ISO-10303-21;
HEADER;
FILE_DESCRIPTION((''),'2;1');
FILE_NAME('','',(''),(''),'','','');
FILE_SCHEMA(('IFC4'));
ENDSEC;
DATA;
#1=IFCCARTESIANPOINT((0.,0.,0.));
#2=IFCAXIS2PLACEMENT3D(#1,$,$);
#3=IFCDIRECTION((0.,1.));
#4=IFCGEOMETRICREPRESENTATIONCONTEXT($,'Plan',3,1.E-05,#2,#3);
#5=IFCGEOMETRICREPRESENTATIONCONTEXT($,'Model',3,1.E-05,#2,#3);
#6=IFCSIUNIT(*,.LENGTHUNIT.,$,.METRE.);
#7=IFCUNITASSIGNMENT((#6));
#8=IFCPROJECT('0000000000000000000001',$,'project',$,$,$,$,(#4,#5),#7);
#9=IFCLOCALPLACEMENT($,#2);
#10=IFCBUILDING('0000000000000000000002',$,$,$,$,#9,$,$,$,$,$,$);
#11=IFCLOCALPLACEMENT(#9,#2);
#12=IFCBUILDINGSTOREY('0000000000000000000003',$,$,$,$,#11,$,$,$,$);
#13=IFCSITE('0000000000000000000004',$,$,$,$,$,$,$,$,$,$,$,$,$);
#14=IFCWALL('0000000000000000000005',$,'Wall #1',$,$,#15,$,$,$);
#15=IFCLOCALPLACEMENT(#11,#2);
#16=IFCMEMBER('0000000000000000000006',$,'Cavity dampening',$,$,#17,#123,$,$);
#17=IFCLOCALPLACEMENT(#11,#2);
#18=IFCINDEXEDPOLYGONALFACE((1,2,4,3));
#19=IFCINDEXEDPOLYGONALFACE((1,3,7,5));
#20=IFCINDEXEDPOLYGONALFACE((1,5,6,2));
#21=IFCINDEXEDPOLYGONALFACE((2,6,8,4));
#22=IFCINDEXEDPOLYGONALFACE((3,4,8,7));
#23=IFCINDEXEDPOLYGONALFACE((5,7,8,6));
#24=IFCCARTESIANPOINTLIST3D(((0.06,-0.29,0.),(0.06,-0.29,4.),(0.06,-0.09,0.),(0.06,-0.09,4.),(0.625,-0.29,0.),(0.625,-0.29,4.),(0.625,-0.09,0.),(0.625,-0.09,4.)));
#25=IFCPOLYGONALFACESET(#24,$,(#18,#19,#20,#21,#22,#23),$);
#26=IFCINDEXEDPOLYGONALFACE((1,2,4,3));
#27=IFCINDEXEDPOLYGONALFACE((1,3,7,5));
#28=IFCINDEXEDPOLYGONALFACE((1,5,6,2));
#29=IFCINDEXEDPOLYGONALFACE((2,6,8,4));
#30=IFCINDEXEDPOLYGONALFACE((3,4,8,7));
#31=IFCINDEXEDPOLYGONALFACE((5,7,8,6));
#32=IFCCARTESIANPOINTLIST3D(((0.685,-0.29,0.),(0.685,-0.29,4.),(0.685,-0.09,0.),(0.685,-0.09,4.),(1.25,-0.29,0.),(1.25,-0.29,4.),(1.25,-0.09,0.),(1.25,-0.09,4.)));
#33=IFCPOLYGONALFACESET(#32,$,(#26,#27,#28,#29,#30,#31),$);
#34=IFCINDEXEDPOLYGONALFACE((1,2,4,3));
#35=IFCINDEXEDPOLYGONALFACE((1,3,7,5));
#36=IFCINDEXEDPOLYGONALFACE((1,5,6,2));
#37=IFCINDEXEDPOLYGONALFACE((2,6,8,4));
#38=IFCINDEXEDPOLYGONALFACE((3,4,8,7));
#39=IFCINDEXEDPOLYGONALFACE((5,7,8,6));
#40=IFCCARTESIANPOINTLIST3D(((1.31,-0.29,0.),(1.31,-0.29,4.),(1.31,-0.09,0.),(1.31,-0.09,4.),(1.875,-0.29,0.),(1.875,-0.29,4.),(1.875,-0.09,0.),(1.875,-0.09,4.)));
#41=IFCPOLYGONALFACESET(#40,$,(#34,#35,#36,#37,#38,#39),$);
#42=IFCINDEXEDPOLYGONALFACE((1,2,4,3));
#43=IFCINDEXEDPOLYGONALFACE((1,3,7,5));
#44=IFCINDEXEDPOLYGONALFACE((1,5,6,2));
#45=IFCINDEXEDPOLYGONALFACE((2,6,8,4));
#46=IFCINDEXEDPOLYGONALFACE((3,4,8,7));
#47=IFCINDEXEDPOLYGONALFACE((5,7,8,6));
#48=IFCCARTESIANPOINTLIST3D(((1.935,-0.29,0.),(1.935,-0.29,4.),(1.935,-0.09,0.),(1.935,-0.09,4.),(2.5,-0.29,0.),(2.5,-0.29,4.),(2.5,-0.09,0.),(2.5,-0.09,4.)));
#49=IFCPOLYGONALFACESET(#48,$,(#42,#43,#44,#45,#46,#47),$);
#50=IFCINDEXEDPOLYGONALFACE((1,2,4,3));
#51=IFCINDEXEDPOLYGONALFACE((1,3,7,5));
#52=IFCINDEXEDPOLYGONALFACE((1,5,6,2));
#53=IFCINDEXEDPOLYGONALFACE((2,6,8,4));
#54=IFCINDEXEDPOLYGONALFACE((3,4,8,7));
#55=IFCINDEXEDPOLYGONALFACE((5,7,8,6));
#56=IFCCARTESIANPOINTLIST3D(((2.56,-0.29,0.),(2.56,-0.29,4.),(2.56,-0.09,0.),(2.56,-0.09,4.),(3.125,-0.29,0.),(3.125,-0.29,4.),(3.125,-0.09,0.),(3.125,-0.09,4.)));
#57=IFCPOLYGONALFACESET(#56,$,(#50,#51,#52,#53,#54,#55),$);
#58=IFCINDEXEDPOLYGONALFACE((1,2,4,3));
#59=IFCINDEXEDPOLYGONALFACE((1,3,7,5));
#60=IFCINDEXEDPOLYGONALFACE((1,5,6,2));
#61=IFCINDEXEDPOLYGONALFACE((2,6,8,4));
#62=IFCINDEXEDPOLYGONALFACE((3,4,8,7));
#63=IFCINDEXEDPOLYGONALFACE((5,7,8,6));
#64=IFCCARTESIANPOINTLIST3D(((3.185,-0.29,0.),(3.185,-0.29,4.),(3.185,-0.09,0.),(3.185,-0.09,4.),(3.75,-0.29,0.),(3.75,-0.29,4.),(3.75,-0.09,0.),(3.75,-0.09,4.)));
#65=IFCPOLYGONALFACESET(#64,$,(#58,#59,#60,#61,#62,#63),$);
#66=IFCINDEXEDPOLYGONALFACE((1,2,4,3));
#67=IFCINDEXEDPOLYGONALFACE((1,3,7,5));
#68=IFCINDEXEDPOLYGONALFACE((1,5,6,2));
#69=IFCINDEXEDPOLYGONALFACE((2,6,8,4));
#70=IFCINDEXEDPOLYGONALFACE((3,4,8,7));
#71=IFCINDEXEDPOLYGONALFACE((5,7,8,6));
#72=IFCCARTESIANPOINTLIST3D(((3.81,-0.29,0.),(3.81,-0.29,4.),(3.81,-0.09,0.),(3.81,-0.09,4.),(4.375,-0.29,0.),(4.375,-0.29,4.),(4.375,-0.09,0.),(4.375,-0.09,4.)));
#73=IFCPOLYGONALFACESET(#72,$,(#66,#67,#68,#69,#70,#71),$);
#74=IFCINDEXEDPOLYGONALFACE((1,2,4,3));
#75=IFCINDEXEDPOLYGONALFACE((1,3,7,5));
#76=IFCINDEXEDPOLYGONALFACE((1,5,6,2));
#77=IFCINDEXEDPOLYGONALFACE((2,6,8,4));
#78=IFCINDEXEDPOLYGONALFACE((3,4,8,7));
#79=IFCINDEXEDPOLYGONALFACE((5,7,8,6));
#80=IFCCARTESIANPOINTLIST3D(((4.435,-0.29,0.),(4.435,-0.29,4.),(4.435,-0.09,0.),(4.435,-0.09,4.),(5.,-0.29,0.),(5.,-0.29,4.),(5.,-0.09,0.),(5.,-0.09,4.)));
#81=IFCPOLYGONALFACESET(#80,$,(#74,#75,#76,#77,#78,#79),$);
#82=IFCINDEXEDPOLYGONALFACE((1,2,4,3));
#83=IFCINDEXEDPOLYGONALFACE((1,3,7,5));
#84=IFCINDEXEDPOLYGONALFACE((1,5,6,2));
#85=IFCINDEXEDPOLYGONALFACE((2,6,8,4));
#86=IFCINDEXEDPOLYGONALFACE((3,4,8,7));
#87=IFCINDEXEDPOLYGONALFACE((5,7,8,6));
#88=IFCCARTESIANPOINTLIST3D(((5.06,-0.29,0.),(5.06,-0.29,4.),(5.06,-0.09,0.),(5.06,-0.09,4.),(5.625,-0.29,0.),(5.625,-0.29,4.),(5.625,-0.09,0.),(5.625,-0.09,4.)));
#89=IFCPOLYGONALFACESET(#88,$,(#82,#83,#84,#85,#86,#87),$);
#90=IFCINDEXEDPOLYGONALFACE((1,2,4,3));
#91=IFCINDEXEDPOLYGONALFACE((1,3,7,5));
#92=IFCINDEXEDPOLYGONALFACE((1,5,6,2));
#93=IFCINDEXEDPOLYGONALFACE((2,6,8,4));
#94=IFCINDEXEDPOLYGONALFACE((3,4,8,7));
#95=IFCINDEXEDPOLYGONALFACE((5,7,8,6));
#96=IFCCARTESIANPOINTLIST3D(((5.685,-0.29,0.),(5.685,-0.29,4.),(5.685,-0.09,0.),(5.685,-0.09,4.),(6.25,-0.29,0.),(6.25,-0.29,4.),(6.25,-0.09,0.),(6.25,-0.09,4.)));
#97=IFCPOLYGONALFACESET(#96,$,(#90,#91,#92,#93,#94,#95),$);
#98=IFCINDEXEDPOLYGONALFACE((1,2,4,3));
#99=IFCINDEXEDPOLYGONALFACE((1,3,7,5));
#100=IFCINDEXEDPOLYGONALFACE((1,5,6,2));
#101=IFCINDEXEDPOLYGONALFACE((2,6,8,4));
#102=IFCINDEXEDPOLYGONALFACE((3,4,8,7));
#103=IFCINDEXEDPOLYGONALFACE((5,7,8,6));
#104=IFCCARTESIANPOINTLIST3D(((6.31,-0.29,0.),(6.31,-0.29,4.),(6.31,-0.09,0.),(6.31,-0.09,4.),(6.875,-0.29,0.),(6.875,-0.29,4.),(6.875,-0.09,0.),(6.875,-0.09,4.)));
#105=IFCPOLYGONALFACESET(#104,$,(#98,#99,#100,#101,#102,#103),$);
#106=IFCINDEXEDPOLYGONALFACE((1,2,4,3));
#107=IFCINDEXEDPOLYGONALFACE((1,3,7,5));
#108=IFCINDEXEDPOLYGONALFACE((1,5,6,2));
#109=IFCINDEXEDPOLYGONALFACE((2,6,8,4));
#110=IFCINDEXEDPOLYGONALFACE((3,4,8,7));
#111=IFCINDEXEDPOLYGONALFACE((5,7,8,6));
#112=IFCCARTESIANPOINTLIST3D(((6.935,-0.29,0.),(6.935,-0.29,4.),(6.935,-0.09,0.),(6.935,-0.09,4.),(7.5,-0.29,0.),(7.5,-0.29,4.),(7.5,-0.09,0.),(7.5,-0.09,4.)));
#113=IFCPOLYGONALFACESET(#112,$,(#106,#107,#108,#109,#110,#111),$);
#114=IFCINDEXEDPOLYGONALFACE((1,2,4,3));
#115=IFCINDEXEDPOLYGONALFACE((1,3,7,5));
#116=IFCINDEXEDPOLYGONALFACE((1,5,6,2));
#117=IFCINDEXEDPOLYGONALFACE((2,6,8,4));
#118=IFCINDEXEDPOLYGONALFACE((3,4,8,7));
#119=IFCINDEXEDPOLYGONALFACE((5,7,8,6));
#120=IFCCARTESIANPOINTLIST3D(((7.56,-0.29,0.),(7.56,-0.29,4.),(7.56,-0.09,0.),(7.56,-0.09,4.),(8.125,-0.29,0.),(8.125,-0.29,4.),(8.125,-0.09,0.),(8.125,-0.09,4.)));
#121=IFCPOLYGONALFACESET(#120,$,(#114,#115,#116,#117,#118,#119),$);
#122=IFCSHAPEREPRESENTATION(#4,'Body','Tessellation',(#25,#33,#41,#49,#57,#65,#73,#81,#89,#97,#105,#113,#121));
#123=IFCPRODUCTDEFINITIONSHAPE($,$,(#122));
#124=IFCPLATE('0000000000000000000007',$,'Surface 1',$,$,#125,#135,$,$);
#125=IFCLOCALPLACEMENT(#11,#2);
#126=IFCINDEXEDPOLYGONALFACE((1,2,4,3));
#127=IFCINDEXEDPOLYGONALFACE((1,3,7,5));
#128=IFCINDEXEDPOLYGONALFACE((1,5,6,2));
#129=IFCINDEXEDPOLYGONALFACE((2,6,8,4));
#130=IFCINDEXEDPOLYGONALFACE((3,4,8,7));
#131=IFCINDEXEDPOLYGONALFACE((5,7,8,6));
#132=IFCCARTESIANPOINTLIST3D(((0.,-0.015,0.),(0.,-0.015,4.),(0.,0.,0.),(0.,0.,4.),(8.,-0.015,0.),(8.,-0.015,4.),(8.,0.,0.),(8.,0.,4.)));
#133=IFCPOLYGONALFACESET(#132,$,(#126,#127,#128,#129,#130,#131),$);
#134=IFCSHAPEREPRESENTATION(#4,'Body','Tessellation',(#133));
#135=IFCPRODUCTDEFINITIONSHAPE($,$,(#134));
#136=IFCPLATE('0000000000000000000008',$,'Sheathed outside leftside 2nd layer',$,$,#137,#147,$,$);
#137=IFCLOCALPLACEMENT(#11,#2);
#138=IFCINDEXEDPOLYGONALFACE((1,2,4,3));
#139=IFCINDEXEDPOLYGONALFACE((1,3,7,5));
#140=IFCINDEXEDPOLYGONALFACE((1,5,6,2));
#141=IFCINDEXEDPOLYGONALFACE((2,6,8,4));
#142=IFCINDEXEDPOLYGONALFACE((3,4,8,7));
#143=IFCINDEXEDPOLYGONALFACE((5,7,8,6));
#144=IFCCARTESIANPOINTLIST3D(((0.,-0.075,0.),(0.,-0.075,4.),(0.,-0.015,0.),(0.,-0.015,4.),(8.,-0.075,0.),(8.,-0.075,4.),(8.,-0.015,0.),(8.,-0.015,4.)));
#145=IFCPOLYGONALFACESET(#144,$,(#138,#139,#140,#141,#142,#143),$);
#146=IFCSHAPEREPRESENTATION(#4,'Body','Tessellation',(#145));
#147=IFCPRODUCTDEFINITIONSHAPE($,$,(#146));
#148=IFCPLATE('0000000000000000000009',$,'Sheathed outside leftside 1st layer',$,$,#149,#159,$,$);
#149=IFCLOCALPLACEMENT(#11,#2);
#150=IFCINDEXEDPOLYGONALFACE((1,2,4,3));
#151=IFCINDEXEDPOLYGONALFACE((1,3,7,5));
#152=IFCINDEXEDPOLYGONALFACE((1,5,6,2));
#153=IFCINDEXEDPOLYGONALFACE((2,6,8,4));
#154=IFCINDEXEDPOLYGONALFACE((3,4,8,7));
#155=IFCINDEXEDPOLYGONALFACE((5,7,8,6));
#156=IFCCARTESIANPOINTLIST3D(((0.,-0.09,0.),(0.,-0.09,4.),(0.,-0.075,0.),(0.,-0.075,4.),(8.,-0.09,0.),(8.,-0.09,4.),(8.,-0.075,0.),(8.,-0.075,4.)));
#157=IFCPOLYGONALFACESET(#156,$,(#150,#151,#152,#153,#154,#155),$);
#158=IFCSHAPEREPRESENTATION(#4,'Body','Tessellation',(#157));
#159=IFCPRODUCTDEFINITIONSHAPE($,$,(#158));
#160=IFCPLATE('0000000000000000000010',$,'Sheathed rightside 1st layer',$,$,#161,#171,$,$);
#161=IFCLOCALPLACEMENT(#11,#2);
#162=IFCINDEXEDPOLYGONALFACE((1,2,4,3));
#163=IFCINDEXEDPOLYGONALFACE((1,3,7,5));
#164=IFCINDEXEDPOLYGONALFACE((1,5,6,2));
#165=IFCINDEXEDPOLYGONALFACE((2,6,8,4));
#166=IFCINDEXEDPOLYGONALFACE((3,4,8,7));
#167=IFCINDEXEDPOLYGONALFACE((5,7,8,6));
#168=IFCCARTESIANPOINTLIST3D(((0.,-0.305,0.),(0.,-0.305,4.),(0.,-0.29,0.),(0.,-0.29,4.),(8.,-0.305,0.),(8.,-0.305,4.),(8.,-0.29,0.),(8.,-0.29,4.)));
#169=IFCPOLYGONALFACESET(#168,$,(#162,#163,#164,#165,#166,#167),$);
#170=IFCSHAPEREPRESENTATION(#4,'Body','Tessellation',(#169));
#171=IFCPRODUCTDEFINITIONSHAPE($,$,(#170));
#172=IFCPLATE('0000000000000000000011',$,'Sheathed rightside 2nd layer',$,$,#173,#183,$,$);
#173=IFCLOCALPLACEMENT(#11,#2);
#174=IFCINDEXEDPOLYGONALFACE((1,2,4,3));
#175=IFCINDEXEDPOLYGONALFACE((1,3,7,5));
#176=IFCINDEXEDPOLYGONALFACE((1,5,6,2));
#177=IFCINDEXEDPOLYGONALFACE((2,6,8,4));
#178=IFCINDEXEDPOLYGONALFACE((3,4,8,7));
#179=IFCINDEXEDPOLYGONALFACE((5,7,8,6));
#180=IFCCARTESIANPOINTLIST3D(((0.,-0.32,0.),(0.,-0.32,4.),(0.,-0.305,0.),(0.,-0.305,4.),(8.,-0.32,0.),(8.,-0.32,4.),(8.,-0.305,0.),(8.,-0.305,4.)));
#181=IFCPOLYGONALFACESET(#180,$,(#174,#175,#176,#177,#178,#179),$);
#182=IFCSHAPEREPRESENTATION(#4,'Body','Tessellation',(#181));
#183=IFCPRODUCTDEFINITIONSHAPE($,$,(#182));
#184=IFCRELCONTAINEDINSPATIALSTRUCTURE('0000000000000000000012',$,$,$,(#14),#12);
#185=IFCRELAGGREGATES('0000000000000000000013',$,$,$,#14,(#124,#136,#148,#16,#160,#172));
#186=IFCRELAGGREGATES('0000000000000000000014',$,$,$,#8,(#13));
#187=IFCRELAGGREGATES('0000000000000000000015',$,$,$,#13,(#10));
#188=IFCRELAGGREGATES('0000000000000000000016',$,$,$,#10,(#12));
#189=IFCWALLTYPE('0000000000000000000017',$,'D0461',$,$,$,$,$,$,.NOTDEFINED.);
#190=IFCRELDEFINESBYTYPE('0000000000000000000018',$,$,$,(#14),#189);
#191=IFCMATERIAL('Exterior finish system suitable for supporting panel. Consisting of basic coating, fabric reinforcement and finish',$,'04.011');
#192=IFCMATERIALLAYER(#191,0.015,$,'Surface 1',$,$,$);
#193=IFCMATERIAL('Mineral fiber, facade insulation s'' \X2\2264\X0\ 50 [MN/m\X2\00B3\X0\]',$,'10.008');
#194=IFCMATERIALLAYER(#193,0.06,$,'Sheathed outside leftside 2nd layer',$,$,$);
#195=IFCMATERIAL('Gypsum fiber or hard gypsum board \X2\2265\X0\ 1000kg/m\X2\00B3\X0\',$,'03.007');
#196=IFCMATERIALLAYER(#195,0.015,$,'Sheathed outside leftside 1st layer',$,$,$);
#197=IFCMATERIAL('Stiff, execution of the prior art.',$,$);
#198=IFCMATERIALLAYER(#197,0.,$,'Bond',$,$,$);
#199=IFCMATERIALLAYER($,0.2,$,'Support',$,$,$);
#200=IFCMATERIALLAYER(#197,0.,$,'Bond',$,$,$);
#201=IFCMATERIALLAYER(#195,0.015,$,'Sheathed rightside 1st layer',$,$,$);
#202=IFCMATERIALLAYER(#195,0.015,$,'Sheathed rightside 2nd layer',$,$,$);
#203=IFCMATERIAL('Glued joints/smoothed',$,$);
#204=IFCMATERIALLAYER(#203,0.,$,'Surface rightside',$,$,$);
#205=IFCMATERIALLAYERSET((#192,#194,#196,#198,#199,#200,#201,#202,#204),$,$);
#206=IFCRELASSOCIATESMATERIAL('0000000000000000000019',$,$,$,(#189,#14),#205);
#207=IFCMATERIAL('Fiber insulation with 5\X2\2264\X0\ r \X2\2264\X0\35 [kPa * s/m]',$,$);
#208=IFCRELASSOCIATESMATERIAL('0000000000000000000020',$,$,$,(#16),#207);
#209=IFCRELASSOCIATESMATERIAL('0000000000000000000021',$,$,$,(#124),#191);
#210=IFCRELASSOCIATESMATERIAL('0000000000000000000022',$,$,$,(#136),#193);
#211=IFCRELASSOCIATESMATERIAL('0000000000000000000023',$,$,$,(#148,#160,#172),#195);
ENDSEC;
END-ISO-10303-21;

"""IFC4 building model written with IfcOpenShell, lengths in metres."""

from ifc_helpers import new_model, si_unit, direction, frame, frame_2d, origin, origin_with_axes, place, context, project, spatial, rectangle, extrude, material, layer, layer_set, type_object, element, aggregate, save


model = new_model("IFC4")

# Units and contexts
plan_context = context("Plan", 3, precision=1e-05, world=origin(), true_north=direction((0.0, 1.0)))
model_context = context("Model", 3, precision=1e-05, world=origin(), true_north=direction((0.0, 1.0)))
ifc_project = project(units=[si_unit("LENGTHUNIT", "METRE")], contexts=[plan_context, model_context])

# Site, building, storey
site = spatial("IfcSite", under=ifc_project)
building_placement = place(None, origin())
building = spatial("IfcBuilding", under=site, at=building_placement)
storey_placement = place(building_placement, origin())
storey = spatial("IfcBuildingStorey", under=building, at=storey_placement)

# Wall, member, plates
ifc_material_1 = material(Name="Exterior finish system suitable for supporting panel. Consisting of basic coating, fabric reinforcement and finish", Category="04.011")
ifc_layer_1 = layer(ifc_material_1, 0.015, Name="Surface 1")
ifc_material_2 = material(Name="Mineral fiber, facade insulation s' ≤ 50 [MN/m³]", Category="10.008")
ifc_layer_2 = layer(ifc_material_2, 0.06, Name="Sheathed outside leftside 2nd layer")
ifc_material_3 = material(Name="Gypsum fiber or hard gypsum board ≥ 1000kg/m³", Category="03.007")
ifc_layer_3 = layer(ifc_material_3, 0.015, Name="Sheathed outside leftside 1st layer")
ifc_material_4 = material(Name="Stiff, execution of the prior art.")
ifc_layer_4 = layer(ifc_material_4, 0.0, Name="Bond")
ifc_layer_5 = layer(None, 0.2, Name="Support")
ifc_layer_6 = layer(ifc_material_4, 0.0, Name="Bond")
ifc_layer_7 = layer(ifc_material_3, 0.015, Name="Sheathed rightside 1st layer")
ifc_layer_8 = layer(ifc_material_3, 0.015, Name="Sheathed rightside 2nd layer")
ifc_material_5 = material(Name="Glued joints/smoothed")
ifc_layer_9 = layer(ifc_material_5, 0.0, Name="Surface rightside")
ifc_layer_set = layer_set([ifc_layer_1, ifc_layer_2, ifc_layer_3, ifc_layer_4, ifc_layer_5, ifc_layer_6, ifc_layer_7, ifc_layer_8, ifc_layer_9])
wall_type = type_object("IfcWallType", Name="D0461", PredefinedType="NOTDEFINED", material=ifc_layer_set)
wall_placement = place(None, frame((0.0, 0.0, 0.0), z_axis=(0.0, -1.0, 0.0), x_axis=(1.0, 0.0, 0.0)))
wall = element("IfcWall", 1, at=wall_placement, inside=storey, type_object=wall_type, material=ifc_layer_set, Name="Wall #1")
ifc_material_6 = material(Name="Fiber insulation with 5≤ r ≤35 [kPa * s/m]")
member_1_placement = place(wall_placement, origin())
member_1 = element("IfcMember", 2, at=member_1_placement, material=ifc_material_6, Name="Cavity dampening", context=plan_context, shape_type="SweptSolid", body=[
    extrude(rectangle(XDim=0.565, YDim=0.2, at=frame_2d((0.2825, 0.1), x_axis=(1.0, 0.0))), frame((0.06, 4.0, 0.09), z_axis=(0.0, -1.0, 0.0), x_axis=(1.0, 0.0, 0.0)), (0.0, 0.0, 1.0), 4.0),
    extrude(rectangle(XDim=0.565, YDim=0.2, at=frame_2d((0.2825, 0.1), x_axis=(1.0, 0.0))), frame((0.685, 4.0, 0.09), z_axis=(0.0, -1.0, 0.0), x_axis=(1.0, 0.0, 0.0)), (0.0, 0.0, 1.0), 4.0),
    extrude(rectangle(XDim=0.565, YDim=0.2, at=frame_2d((0.2825, 0.1), x_axis=(1.0, 0.0))), frame((1.31, 4.0, 0.09), z_axis=(0.0, -1.0, 0.0), x_axis=(1.0, 0.0, 0.0)), (0.0, 0.0, 1.0), 4.0),
    extrude(rectangle(XDim=0.565, YDim=0.2, at=frame_2d((0.2825, 0.1), x_axis=(1.0, 0.0))), frame((1.935, 4.0, 0.09), z_axis=(0.0, -1.0, 0.0), x_axis=(1.0, 0.0, 0.0)), (0.0, 0.0, 1.0), 4.0),
    extrude(rectangle(XDim=0.565, YDim=0.2, at=frame_2d((0.2825, 0.1), x_axis=(1.0, 0.0))), frame((2.56, 4.0, 0.09), z_axis=(0.0, -1.0, 0.0), x_axis=(1.0, 0.0, 0.0)), (0.0, 0.0, 1.0), 4.0),
    extrude(rectangle(XDim=0.565, YDim=0.2, at=frame_2d((0.2825, 0.1), x_axis=(1.0, 0.0))), frame((3.185, 4.0, 0.09), z_axis=(0.0, -1.0, 0.0), x_axis=(1.0, 0.0, 0.0)), (0.0, 0.0, 1.0), 4.0),
    extrude(rectangle(XDim=0.565, YDim=0.2, at=frame_2d((0.2825, 0.1), x_axis=(1.0, 0.0))), frame((3.81, 4.0, 0.09), z_axis=(0.0, -1.0, 0.0), x_axis=(1.0, 0.0, 0.0)), (0.0, 0.0, 1.0), 4.0),
    extrude(rectangle(XDim=0.565, YDim=0.2, at=frame_2d((0.2825, 0.1), x_axis=(1.0, 0.0))), frame((4.435, 4.0, 0.09), z_axis=(0.0, -1.0, 0.0), x_axis=(1.0, 0.0, 0.0)), (0.0, 0.0, 1.0), 4.0),
    extrude(rectangle(XDim=0.565, YDim=0.2, at=frame_2d((0.2825, 0.1), x_axis=(1.0, 0.0))), frame((5.06, 4.0, 0.09), z_axis=(0.0, -1.0, 0.0), x_axis=(1.0, 0.0, 0.0)), (0.0, 0.0, 1.0), 4.0),
    extrude(rectangle(XDim=0.565, YDim=0.2, at=frame_2d((0.2825, 0.1), x_axis=(1.0, 0.0))), frame((5.685, 4.0, 0.09), z_axis=(0.0, -1.0, 0.0), x_axis=(1.0, 0.0, 0.0)), (0.0, 0.0, 1.0), 4.0),
    extrude(rectangle(XDim=0.565, YDim=0.2, at=frame_2d((0.2825, 0.1), x_axis=(1.0, 0.0))), frame((6.31, 4.0, 0.09), z_axis=(0.0, -1.0, 0.0), x_axis=(1.0, 0.0, 0.0)), (0.0, 0.0, 1.0), 4.0),
    extrude(rectangle(XDim=0.565, YDim=0.2, at=frame_2d((0.2825, 0.1), x_axis=(1.0, 0.0))), frame((6.935, 4.0, 0.09), z_axis=(0.0, -1.0, 0.0), x_axis=(1.0, 0.0, 0.0)), (0.0, 0.0, 1.0), 4.0),
    extrude(rectangle(XDim=0.565, YDim=0.2, at=frame_2d((0.2825, 0.1), x_axis=(1.0, 0.0))), frame((7.56, 4.0, 0.09), z_axis=(0.0, -1.0, 0.0), x_axis=(1.0, 0.0, 0.0)), (0.0, 0.0, 1.0), 4.0),
])
plate_1_placement = place(wall_placement, origin())
plate_1 = element("IfcPlate", 3, at=plate_1_placement, material=ifc_material_1, Name="Surface 1", context=plan_context, shape_type="SweptSolid", body=[
    extrude(rectangle(XDim=8.0, YDim=4.0, at=frame_2d((4.0, 2.0), x_axis=(1.0, 0.0))), origin_with_axes(), (0.0, 0.0, 1.0), 0.015),
])
plate_2_placement = place(wall_placement, origin())
plate_2 = element("IfcPlate", 4, at=plate_2_placement, material=ifc_material_2, Name="Sheathed outside leftside 2nd layer", context=plan_context, shape_type="SweptSolid", body=[
    extrude(rectangle(XDim=8.0, YDim=4.0, at=frame_2d((4.0, 2.0), x_axis=(1.0, 0.0))), frame((0.0, 0.0, 0.015), z_axis=(0.0, 0.0, 1.0), x_axis=(1.0, 0.0, 0.0)), (0.0, 0.0, 1.0), 0.06),
])
plate_3_placement = place(wall_placement, origin())
plate_3 = element("IfcPlate", 5, at=plate_3_placement, material=ifc_material_3, Name="Sheathed outside leftside 1st layer", context=plan_context, shape_type="SweptSolid", body=[
    extrude(rectangle(XDim=8.0, YDim=4.0, at=frame_2d((4.0, 2.0), x_axis=(1.0, 0.0))), frame((0.0, 0.0, 0.075), z_axis=(0.0, 0.0, 1.0), x_axis=(1.0, 0.0, 0.0)), (0.0, 0.0, 1.0), 0.015),
])
plate_4_placement = place(wall_placement, origin())
plate_4 = element("IfcPlate", 6, at=plate_4_placement, material=ifc_material_3, Name="Sheathed rightside 1st layer", context=plan_context, shape_type="SweptSolid", body=[
    extrude(rectangle(XDim=8.0, YDim=4.0, at=frame_2d((4.0, 2.0), x_axis=(1.0, 0.0))), frame((0.0, 0.0, 0.29), z_axis=(0.0, 0.0, 1.0), x_axis=(1.0, 0.0, 0.0)), (0.0, 0.0, 1.0), 0.015),
])
plate_5_placement = place(wall_placement, origin())
plate_5 = element("IfcPlate", 7, at=plate_5_placement, material=ifc_material_3, Name="Sheathed rightside 2nd layer", context=plan_context, shape_type="SweptSolid", body=[
    extrude(rectangle(XDim=8.0, YDim=4.0, at=frame_2d((4.0, 2.0), x_axis=(1.0, 0.0))), frame((0.0, 0.0, 0.305), z_axis=(0.0, 0.0, 1.0), x_axis=(1.0, 0.0, 0.0)), (0.0, 0.0, 1.0), 0.015),
])
aggregate(wall, [plate_1, plate_2, plate_3, member_1, plate_4, plate_5])

save(model, "model.ifc")
